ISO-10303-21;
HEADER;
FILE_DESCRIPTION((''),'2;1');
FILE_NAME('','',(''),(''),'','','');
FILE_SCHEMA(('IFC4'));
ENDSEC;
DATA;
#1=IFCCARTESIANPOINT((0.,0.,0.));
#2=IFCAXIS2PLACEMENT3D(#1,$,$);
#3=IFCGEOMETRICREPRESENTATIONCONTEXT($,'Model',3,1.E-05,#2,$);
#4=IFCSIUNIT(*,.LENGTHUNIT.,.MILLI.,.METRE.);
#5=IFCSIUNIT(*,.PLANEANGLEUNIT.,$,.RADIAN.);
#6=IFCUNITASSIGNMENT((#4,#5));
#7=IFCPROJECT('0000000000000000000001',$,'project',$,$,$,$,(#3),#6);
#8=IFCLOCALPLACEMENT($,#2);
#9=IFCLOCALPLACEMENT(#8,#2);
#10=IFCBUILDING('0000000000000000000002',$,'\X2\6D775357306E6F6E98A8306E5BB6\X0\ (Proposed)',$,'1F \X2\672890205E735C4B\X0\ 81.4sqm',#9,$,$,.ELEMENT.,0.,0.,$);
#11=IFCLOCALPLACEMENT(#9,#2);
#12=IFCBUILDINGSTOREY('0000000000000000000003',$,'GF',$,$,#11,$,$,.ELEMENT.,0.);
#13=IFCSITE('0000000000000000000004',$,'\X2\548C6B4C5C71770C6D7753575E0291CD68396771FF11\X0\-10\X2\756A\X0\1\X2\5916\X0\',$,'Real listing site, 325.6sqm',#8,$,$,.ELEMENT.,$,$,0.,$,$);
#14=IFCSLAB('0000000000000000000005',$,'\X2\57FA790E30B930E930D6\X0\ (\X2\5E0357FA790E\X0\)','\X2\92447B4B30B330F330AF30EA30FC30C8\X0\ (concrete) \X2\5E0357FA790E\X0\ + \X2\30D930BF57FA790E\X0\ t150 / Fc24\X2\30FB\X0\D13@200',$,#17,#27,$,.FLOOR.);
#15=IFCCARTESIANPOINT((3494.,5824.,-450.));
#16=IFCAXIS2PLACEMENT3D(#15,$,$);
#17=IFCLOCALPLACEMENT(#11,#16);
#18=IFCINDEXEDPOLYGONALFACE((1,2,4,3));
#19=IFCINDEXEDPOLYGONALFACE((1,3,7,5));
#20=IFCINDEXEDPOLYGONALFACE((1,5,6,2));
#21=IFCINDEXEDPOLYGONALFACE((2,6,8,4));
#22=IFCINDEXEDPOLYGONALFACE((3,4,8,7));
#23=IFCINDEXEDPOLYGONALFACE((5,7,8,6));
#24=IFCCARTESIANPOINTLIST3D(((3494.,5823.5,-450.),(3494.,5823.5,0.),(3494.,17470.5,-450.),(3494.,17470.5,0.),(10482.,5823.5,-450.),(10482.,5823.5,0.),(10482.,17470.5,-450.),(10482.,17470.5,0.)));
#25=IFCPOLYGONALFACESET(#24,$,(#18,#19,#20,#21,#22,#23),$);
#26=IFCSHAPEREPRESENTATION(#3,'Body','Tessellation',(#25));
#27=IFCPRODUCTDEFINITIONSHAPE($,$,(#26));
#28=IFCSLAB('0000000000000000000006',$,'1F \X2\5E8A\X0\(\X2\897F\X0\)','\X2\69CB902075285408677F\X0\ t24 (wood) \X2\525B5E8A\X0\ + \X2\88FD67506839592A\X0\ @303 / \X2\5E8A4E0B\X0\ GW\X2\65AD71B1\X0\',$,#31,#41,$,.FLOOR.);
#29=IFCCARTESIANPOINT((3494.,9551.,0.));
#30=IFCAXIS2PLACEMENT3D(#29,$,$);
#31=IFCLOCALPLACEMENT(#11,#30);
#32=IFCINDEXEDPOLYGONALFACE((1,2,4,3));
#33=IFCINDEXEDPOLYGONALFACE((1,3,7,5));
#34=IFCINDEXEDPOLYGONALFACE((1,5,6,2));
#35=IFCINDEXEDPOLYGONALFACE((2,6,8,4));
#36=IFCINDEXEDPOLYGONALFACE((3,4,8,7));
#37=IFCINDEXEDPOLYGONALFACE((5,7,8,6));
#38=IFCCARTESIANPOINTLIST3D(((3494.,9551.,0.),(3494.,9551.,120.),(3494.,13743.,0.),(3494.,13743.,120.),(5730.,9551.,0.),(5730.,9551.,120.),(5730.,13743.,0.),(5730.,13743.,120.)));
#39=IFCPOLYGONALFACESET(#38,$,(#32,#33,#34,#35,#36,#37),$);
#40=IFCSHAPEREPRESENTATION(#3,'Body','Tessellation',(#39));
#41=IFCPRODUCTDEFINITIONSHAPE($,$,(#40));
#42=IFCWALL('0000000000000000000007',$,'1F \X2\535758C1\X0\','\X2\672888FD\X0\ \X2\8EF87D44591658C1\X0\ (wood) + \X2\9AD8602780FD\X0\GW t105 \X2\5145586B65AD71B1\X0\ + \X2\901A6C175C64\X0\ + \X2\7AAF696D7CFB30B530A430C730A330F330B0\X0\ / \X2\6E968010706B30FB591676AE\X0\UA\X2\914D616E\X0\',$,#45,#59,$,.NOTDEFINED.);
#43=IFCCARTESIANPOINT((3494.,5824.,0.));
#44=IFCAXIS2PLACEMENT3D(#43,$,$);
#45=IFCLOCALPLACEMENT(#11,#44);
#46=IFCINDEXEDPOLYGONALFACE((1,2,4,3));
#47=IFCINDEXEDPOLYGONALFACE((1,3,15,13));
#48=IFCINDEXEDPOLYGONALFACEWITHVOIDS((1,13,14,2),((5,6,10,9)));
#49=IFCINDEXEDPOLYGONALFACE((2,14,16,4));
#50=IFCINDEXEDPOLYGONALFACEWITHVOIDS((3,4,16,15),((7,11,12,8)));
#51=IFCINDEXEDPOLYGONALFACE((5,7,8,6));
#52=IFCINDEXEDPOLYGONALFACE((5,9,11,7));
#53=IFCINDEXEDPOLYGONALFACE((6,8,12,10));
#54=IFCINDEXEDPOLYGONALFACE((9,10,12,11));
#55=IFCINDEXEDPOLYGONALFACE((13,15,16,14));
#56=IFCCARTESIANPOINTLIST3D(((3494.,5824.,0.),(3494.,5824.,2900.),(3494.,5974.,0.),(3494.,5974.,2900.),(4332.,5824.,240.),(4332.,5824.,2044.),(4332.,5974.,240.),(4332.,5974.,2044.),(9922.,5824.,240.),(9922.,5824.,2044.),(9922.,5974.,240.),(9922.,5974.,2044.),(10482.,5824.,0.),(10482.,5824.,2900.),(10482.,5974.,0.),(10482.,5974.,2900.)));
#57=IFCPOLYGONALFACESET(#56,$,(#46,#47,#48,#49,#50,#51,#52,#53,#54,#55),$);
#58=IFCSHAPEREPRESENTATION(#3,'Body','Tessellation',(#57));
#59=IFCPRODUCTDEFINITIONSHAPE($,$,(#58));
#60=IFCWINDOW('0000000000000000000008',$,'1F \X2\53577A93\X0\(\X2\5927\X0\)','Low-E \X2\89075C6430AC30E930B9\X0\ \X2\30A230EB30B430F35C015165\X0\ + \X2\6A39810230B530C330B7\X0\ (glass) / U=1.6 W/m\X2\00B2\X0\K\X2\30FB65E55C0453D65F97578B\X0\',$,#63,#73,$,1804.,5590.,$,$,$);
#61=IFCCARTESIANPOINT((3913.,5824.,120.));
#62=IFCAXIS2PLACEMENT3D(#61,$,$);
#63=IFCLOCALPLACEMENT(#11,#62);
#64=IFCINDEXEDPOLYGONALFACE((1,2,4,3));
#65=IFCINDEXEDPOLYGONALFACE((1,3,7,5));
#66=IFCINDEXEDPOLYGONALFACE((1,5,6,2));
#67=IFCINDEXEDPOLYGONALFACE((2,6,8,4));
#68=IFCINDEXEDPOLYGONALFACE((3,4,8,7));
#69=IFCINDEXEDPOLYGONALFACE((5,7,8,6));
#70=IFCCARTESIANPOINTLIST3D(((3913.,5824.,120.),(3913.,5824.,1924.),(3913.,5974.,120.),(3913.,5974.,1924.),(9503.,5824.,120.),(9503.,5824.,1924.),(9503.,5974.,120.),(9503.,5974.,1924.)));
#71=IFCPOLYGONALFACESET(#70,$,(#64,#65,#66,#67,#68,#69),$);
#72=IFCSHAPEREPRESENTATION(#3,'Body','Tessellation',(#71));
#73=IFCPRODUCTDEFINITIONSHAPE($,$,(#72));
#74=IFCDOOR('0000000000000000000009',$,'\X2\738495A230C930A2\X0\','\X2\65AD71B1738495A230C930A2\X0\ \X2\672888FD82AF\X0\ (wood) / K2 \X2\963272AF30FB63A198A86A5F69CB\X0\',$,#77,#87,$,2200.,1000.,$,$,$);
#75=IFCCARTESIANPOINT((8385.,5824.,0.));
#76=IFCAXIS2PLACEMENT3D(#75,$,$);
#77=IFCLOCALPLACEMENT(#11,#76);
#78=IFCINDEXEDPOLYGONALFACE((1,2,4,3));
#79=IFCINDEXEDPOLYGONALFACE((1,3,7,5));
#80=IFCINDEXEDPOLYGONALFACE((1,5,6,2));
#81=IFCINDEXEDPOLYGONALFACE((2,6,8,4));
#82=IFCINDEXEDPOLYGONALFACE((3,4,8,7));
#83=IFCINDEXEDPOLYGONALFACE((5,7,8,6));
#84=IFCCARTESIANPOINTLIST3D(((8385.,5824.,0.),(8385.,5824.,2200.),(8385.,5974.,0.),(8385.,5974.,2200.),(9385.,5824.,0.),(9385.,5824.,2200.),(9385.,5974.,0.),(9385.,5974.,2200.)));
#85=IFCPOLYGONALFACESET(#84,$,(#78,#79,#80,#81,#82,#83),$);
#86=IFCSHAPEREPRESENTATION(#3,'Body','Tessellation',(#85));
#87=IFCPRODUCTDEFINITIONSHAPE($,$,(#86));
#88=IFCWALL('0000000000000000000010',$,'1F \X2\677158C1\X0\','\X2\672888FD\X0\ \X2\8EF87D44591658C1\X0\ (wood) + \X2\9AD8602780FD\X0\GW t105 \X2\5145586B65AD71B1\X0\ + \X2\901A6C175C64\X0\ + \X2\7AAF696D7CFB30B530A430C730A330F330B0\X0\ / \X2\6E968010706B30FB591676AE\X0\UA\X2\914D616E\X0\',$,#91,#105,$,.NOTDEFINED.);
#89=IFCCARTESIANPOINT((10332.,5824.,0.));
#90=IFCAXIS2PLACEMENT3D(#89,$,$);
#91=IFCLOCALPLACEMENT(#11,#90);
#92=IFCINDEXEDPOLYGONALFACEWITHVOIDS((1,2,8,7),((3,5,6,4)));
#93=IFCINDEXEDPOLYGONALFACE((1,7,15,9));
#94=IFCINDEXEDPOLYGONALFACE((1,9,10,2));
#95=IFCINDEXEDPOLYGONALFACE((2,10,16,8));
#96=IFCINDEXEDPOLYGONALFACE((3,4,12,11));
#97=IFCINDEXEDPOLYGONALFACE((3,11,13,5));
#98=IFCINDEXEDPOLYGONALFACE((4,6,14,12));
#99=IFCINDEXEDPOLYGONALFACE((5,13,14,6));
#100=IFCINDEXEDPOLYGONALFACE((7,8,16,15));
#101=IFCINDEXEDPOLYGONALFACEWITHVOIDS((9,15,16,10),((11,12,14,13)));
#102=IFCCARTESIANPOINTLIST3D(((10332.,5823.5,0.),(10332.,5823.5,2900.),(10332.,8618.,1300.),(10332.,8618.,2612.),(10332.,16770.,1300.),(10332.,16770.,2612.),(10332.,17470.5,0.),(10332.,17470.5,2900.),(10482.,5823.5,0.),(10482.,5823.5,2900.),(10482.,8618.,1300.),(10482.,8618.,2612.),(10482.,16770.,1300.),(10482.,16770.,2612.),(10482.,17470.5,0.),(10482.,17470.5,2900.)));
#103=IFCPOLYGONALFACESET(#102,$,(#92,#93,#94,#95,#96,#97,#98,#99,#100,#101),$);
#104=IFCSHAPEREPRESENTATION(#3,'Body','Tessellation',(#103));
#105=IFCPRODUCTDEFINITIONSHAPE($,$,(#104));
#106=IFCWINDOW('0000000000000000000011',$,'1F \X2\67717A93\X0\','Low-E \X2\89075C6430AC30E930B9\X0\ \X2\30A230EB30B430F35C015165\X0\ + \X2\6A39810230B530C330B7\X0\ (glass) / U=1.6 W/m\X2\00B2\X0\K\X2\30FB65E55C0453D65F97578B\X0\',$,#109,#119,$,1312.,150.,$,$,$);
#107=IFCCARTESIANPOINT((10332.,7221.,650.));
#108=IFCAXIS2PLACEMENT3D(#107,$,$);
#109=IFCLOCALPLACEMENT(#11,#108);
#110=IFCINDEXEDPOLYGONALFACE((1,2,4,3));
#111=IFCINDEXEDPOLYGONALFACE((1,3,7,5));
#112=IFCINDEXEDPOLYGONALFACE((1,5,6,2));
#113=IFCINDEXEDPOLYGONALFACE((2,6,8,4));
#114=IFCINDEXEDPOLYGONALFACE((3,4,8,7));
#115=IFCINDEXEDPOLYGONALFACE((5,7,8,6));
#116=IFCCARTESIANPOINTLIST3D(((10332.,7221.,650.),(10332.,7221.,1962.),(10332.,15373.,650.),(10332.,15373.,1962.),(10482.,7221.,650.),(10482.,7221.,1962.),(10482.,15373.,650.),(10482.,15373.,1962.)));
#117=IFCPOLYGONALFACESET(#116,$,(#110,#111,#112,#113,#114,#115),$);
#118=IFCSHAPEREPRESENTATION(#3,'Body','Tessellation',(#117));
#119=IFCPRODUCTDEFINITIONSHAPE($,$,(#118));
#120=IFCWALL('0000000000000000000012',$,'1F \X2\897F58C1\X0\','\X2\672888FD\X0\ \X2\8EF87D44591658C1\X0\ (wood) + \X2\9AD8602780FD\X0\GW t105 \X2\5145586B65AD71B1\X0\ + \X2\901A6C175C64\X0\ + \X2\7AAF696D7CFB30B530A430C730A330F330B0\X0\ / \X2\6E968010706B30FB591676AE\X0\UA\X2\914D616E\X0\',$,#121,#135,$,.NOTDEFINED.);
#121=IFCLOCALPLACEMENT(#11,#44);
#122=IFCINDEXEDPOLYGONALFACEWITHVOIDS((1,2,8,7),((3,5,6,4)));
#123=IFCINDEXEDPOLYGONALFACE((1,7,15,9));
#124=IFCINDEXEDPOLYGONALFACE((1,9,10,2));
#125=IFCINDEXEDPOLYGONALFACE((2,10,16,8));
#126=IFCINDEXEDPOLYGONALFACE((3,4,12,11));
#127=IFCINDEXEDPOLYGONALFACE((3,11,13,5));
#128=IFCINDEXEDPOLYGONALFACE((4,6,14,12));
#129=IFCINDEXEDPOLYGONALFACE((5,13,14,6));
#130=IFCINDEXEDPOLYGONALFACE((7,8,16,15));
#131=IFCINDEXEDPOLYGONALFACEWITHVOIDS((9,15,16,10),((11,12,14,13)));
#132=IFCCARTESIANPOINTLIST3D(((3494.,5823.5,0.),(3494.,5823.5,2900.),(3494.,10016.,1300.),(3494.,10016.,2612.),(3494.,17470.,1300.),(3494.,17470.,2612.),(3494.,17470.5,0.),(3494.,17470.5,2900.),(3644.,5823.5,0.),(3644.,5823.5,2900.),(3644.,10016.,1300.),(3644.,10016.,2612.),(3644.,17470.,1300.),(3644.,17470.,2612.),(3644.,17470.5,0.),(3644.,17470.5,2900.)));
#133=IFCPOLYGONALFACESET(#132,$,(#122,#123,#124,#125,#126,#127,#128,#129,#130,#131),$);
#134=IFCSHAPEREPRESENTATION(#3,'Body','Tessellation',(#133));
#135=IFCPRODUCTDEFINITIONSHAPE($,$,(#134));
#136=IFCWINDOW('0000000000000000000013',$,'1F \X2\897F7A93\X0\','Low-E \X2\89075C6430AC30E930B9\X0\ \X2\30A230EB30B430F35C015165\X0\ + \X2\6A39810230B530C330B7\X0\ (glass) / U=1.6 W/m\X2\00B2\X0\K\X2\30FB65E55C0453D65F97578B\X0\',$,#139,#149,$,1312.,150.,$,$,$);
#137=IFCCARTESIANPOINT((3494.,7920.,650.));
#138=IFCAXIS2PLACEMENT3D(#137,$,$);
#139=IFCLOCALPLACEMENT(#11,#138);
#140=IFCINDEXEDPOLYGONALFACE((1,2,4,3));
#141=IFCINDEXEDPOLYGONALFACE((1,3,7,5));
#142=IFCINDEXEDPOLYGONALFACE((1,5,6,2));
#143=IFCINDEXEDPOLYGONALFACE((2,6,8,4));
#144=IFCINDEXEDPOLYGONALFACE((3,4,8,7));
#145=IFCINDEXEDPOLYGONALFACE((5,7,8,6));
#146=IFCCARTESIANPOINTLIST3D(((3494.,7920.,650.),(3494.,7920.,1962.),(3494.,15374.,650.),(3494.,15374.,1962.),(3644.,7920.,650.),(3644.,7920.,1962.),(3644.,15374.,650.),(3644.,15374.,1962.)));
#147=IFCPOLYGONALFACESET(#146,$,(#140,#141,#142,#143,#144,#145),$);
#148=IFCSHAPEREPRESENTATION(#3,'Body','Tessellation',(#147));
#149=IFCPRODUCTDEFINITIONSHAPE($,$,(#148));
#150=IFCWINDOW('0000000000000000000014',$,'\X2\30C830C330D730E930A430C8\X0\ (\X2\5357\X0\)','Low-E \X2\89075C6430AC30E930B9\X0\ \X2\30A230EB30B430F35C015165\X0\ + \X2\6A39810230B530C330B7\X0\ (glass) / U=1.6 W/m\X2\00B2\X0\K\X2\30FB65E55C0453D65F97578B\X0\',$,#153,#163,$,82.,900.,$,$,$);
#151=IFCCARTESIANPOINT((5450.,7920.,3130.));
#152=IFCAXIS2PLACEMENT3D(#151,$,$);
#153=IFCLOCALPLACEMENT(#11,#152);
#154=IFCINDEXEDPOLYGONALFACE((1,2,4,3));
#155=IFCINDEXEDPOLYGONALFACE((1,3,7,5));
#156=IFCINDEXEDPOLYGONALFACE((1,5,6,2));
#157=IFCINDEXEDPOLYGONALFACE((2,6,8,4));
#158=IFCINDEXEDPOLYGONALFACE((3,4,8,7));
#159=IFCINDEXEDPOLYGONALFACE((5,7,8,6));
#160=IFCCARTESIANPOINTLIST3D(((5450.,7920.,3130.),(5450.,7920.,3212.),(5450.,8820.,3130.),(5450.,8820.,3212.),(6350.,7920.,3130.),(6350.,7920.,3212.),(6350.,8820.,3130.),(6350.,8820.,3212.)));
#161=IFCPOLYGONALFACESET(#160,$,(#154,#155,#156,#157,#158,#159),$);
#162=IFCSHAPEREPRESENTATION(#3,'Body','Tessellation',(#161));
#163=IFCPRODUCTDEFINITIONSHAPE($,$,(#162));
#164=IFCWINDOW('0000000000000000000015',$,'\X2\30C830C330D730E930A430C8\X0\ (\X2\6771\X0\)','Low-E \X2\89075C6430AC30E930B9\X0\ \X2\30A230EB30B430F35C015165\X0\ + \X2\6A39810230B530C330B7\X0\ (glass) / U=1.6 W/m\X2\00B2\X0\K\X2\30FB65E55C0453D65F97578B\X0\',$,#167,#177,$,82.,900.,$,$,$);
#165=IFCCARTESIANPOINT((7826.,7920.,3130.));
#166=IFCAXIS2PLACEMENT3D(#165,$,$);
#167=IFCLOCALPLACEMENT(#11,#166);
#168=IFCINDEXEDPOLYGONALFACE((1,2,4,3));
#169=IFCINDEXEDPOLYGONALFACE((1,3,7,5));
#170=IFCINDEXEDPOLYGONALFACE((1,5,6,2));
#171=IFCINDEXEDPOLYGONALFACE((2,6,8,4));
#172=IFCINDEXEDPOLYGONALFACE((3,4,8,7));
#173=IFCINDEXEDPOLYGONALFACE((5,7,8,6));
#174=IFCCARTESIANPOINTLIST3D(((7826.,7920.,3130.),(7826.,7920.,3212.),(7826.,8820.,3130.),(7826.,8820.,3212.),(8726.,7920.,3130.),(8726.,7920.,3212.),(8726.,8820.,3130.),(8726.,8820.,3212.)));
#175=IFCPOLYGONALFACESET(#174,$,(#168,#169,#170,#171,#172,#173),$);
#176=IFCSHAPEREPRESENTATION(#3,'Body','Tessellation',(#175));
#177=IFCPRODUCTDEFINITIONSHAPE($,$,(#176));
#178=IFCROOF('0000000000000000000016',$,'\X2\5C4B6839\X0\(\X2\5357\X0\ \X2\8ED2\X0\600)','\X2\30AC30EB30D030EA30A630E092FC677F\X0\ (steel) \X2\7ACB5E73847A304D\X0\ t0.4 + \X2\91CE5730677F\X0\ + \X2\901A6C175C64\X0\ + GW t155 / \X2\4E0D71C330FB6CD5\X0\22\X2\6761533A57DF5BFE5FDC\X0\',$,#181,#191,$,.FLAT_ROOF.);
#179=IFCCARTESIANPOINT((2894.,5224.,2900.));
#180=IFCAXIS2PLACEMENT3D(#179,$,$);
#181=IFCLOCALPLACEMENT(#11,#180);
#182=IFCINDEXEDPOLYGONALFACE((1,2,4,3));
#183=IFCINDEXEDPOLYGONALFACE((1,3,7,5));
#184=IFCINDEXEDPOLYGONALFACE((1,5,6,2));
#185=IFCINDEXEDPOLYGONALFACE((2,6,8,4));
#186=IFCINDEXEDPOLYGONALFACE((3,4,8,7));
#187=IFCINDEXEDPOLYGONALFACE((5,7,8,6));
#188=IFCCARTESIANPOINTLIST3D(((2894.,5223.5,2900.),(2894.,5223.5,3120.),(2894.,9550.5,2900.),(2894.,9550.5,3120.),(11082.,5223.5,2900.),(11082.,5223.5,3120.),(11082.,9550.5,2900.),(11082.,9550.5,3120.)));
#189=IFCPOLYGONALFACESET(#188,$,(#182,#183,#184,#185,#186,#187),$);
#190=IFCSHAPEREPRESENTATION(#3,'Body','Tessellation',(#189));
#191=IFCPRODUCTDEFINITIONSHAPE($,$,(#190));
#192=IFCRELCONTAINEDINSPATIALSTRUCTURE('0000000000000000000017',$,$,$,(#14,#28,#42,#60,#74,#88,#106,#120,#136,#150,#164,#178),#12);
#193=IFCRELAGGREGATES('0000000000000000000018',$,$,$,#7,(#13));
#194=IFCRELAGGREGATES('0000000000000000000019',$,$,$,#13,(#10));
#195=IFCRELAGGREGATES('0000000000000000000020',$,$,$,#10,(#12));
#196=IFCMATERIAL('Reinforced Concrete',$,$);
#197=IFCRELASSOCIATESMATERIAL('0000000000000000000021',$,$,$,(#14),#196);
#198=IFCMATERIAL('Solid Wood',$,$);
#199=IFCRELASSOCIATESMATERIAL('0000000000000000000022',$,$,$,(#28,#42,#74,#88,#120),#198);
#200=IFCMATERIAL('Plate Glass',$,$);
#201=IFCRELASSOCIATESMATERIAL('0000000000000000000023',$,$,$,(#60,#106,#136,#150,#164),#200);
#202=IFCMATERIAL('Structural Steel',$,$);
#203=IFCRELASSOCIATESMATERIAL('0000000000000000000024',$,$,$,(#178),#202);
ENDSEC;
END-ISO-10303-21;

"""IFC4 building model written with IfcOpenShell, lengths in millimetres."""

from ifc_helpers import new_model, si_unit, frame, frame_2d, origin, place, context, project, spatial, rectangle, extrude, material, element, fill, save


model = new_model("IFC4")

# Units and contexts
model_context = context("Model", 3, precision=1e-05, world=origin())
ifc_project = project(units=[si_unit("LENGTHUNIT", "METRE", prefix="MILLI"), si_unit("PLANEANGLEUNIT", "RADIAN")], contexts=[model_context])

# Site, building, storey
site_placement = place(None, origin())
site = spatial("IfcSite", under=ifc_project, at=site_placement, Name="和歌山県海南市重根東１-10番1外", ObjectType="Real listing site, 325.6sqm", CompositionType="ELEMENT", RefElevation=0.0)
building_placement = place(site_placement, origin())
building = spatial("IfcBuilding", under=site, at=building_placement, Name="海南の潮風の家 (Proposed)", ObjectType="1F 木造平屋 81.4sqm", CompositionType="ELEMENT", ElevationOfRefHeight=0.0, ElevationOfTerrain=0.0)
storey_placement = place(building_placement, origin())
storey = spatial("IfcBuildingStorey", under=building, at=storey_placement, Name="GF", CompositionType="ELEMENT", Elevation=0.0)

# Slabs
ifc_material_1 = material(Name="Reinforced Concrete")
slab_1_placement = place(storey_placement, frame((3494.0, 5824.0, -450.0)))
element("IfcSlab", 1, at=slab_1_placement, inside=storey, material=ifc_material_1, Name="基礎スラブ (布基礎)", Description="鉄筋コンクリート (concrete) 布基礎 + ベタ基礎 t150 / Fc24・D13@200", PredefinedType="FLOOR", context=model_context, shape_type="SweptSolid", body=[
    extrude(rectangle(XDim=6988.0, YDim=11647.0, at=frame_2d((3494.0, 5823.0))), frame((3494.0, 5824.0, -450.0)), (0.0, 0.0, 1.0), 450.0),
])
ifc_material_2 = material(Name="Solid Wood")
slab_2_placement = place(storey_placement, frame((3494.0, 9551.0, 0.0)))
element("IfcSlab", 2, at=slab_2_placement, inside=storey, material=ifc_material_2, Name="1F 床(西)", Description="構造用合板 t24 (wood) 剛床 + 製材根太 @303 / 床下 GW断熱", PredefinedType="FLOOR", context=model_context, shape_type="SweptSolid", body=[
    extrude(rectangle(XDim=2236.0, YDim=4192.0, at=frame_2d((1118.0, 2096.0))), frame((3494.0, 9551.0, 0.0)), (0.0, 0.0, 1.0), 120.0),
])

# Wall, openings, window, door
wall_1_placement = place(storey_placement, frame((3494.0, 5824.0, 0.0)))
wall_1 = element("IfcWall", 3, at=wall_1_placement, inside=storey, material=ifc_material_2, Name="1F 南壁", Description="木製 軸組外壁 (wood) + 高性能GW t105 充填断熱 + 通気層 + 窯業系サイディング / 準耐火・外皮UA配慮", PredefinedType="NOTDEFINED", context=model_context, shape_type="SweptSolid", body=[
    extrude(rectangle(XDim=6988.0, YDim=150.0, at=frame_2d((3494.0, 75.0))), frame((3494.0, 5824.0, 0.0)), (0.0, 0.0, 1.0), 2900.0),
])
opening_1_placement = place(storey_placement, frame((3913.0, 5824.0, 120.0)))
opening_1 = element("IfcOpeningElement", 4, at=opening_1_placement, cuts=wall_1, PredefinedType="NOTDEFINED", context=model_context, shape_type="SweptSolid", body=[
    extrude(rectangle(XDim=5590.0, YDim=150.0, at=frame_2d((2795.0, 75.0))), frame((3913.0, 5824.0, 120.0)), (0.0, 0.0, 1.0), 1804.0),
])
opening_2_placement = place(storey_placement, frame((8385.0, 5824.0, 0.0)))
opening_2 = element("IfcOpeningElement", 5, at=opening_2_placement, cuts=wall_1, PredefinedType="NOTDEFINED", context=model_context, shape_type="SweptSolid", body=[
    extrude(rectangle(XDim=1000.0, YDim=150.0, at=frame_2d((500.0, 75.0))), frame((8385.0, 5824.0, 0.0)), (0.0, 0.0, 1.0), 2200.0),
])
ifc_material_3 = material(Name="Plate Glass")
window_1_placement = place(storey_placement, frame((3913.0, 5824.0, 120.0)))
window_1 = element("IfcWindow", 6, at=window_1_placement, inside=storey, material=ifc_material_3, Name="1F 南窓(大)", Description="Low-E 複層ガラス アルゴン封入 + 樹脂サッシ (glass) / U=1.6 W/m²K・日射取得型", OverallHeight=1804.0, OverallWidth=5590.0, context=model_context, shape_type="SweptSolid", body=[
    extrude(rectangle(XDim=5590.0, YDim=150.0, at=frame_2d((2795.0, 75.0))), frame((3913.0, 5824.0, 120.0)), (0.0, 0.0, 1.0), 1804.0),
])
fill(opening_1, window_1)
door_placement = place(storey_placement, frame((8385.0, 5824.0, 0.0)))
door = element("IfcDoor", 7, at=door_placement, inside=storey, material=ifc_material_2, Name="玄関ドア", Description="断熱玄関ドア 木製芯 (wood) / K2 防犯・採風機構", OverallHeight=2200.0, OverallWidth=1000.0, context=model_context, shape_type="SweptSolid", body=[
    extrude(rectangle(XDim=1000.0, YDim=150.0, at=frame_2d((500.0, 75.0))), frame((8385.0, 5824.0, 0.0)), (0.0, 0.0, 1.0), 2200.0),
])
fill(opening_2, door)

# Walls, openings, windows
wall_2_placement = place(storey_placement, frame((10332.0, 5824.0, 0.0)))
wall_2 = element("IfcWall", 8, at=wall_2_placement, inside=storey, material=ifc_material_2, Name="1F 東壁", Description="木製 軸組外壁 (wood) + 高性能GW t105 充填断熱 + 通気層 + 窯業系サイディング / 準耐火・外皮UA配慮", PredefinedType="NOTDEFINED", context=model_context, shape_type="SweptSolid", body=[
    extrude(rectangle(XDim=150.0, YDim=11647.0, at=frame_2d((75.0, 5823.0))), frame((10332.0, 5824.0, 0.0)), (0.0, 0.0, 1.0), 2900.0),
])
opening_3_placement = place(storey_placement, frame((10332.0, 7221.0, 650.0)))
opening_3 = element("IfcOpeningElement", 9, at=opening_3_placement, cuts=wall_2, PredefinedType="NOTDEFINED", context=model_context, shape_type="SweptSolid", body=[
    extrude(rectangle(XDim=150.0, YDim=8152.0, at=frame_2d((75.0, 4076.0))), frame((10332.0, 7221.0, 650.0)), (0.0, 0.0, 1.0), 1312.0),
])
window_2_placement = place(storey_placement, frame((10332.0, 7221.0, 650.0)))
window_2 = element("IfcWindow", 10, at=window_2_placement, inside=storey, material=ifc_material_3, Name="1F 東窓", Description="Low-E 複層ガラス アルゴン封入 + 樹脂サッシ (glass) / U=1.6 W/m²K・日射取得型", OverallHeight=1312.0, OverallWidth=150.0, context=model_context, shape_type="SweptSolid", body=[
    extrude(rectangle(XDim=150.0, YDim=8152.0, at=frame_2d((75.0, 4076.0))), frame((10332.0, 7221.0, 650.0)), (0.0, 0.0, 1.0), 1312.0),
])
fill(opening_3, window_2)
wall_3_placement = place(storey_placement, frame((3494.0, 5824.0, 0.0)))
wall_3 = element("IfcWall", 11, at=wall_3_placement, inside=storey, material=ifc_material_2, Name="1F 西壁", Description="木製 軸組外壁 (wood) + 高性能GW t105 充填断熱 + 通気層 + 窯業系サイディング / 準耐火・外皮UA配慮", PredefinedType="NOTDEFINED", context=model_context, shape_type="SweptSolid", body=[
    extrude(rectangle(XDim=150.0, YDim=11647.0, at=frame_2d((75.0, 5823.0))), frame((3494.0, 5824.0, 0.0)), (0.0, 0.0, 1.0), 2900.0),
])
opening_4_placement = place(storey_placement, frame((3494.0, 7920.0, 650.0)))
opening_4 = element("IfcOpeningElement", 12, at=opening_4_placement, cuts=wall_3, PredefinedType="NOTDEFINED", context=model_context, shape_type="SweptSolid", body=[
    extrude(rectangle(XDim=150.0, YDim=7454.0, at=frame_2d((75.0, 3727.0))), frame((3494.0, 7920.0, 650.0)), (0.0, 0.0, 1.0), 1312.0),
])
window_3_placement = place(storey_placement, frame((3494.0, 7920.0, 650.0)))
window_3 = element("IfcWindow", 13, at=window_3_placement, inside=storey, material=ifc_material_3, Name="1F 西窓", Description="Low-E 複層ガラス アルゴン封入 + 樹脂サッシ (glass) / U=1.6 W/m²K・日射取得型", OverallHeight=1312.0, OverallWidth=150.0, context=model_context, shape_type="SweptSolid", body=[
    extrude(rectangle(XDim=150.0, YDim=7454.0, at=frame_2d((75.0, 3727.0))), frame((3494.0, 7920.0, 650.0)), (0.0, 0.0, 1.0), 1312.0),
])
fill(opening_4, window_3)

# Windows
window_4_placement = place(storey_placement, frame((5450.0, 7920.0, 3130.0)))
element("IfcWindow", 14, at=window_4_placement, inside=storey, material=ifc_material_3, Name="トップライト (南)", Description="Low-E 複層ガラス アルゴン封入 + 樹脂サッシ (glass) / U=1.6 W/m²K・日射取得型", OverallHeight=82.0, OverallWidth=900.0, context=model_context, shape_type="SweptSolid", body=[
    extrude(rectangle(XDim=900.0, YDim=900.0, at=frame_2d((450.0, 450.0))), frame((5450.0, 7920.0, 3130.0)), (0.0, 0.0, 1.0), 82.0),
])
window_5_placement = place(storey_placement, frame((7826.0, 7920.0, 3130.0)))
element("IfcWindow", 15, at=window_5_placement, inside=storey, material=ifc_material_3, Name="トップライト (東)", Description="Low-E 複層ガラス アルゴン封入 + 樹脂サッシ (glass) / U=1.6 W/m²K・日射取得型", OverallHeight=82.0, OverallWidth=900.0, context=model_context, shape_type="SweptSolid", body=[
    extrude(rectangle(XDim=900.0, YDim=900.0, at=frame_2d((450.0, 450.0))), frame((7826.0, 7920.0, 3130.0)), (0.0, 0.0, 1.0), 82.0),
])

# Roof
ifc_material_4 = material(Name="Structural Steel")
roof_placement = place(storey_placement, frame((2894.0, 5224.0, 2900.0)))
element("IfcRoof", 16, at=roof_placement, inside=storey, material=ifc_material_4, Name="屋根(南 軒600)", Description="ガルバリウム鋼板 (steel) 立平葺き t0.4 + 野地板 + 通気層 + GW t155 / 不燃・法22条区域対応", PredefinedType="FLAT_ROOF", context=model_context, shape_type="SweptSolid", body=[
    extrude(rectangle(XDim=8188.0, YDim=4327.0, at=frame_2d((4094.0, 2163.0))), frame((2894.0, 5224.0, 2900.0)), (0.0, 0.0, 1.0), 220.0),
])

save(model, "model.ifc")
